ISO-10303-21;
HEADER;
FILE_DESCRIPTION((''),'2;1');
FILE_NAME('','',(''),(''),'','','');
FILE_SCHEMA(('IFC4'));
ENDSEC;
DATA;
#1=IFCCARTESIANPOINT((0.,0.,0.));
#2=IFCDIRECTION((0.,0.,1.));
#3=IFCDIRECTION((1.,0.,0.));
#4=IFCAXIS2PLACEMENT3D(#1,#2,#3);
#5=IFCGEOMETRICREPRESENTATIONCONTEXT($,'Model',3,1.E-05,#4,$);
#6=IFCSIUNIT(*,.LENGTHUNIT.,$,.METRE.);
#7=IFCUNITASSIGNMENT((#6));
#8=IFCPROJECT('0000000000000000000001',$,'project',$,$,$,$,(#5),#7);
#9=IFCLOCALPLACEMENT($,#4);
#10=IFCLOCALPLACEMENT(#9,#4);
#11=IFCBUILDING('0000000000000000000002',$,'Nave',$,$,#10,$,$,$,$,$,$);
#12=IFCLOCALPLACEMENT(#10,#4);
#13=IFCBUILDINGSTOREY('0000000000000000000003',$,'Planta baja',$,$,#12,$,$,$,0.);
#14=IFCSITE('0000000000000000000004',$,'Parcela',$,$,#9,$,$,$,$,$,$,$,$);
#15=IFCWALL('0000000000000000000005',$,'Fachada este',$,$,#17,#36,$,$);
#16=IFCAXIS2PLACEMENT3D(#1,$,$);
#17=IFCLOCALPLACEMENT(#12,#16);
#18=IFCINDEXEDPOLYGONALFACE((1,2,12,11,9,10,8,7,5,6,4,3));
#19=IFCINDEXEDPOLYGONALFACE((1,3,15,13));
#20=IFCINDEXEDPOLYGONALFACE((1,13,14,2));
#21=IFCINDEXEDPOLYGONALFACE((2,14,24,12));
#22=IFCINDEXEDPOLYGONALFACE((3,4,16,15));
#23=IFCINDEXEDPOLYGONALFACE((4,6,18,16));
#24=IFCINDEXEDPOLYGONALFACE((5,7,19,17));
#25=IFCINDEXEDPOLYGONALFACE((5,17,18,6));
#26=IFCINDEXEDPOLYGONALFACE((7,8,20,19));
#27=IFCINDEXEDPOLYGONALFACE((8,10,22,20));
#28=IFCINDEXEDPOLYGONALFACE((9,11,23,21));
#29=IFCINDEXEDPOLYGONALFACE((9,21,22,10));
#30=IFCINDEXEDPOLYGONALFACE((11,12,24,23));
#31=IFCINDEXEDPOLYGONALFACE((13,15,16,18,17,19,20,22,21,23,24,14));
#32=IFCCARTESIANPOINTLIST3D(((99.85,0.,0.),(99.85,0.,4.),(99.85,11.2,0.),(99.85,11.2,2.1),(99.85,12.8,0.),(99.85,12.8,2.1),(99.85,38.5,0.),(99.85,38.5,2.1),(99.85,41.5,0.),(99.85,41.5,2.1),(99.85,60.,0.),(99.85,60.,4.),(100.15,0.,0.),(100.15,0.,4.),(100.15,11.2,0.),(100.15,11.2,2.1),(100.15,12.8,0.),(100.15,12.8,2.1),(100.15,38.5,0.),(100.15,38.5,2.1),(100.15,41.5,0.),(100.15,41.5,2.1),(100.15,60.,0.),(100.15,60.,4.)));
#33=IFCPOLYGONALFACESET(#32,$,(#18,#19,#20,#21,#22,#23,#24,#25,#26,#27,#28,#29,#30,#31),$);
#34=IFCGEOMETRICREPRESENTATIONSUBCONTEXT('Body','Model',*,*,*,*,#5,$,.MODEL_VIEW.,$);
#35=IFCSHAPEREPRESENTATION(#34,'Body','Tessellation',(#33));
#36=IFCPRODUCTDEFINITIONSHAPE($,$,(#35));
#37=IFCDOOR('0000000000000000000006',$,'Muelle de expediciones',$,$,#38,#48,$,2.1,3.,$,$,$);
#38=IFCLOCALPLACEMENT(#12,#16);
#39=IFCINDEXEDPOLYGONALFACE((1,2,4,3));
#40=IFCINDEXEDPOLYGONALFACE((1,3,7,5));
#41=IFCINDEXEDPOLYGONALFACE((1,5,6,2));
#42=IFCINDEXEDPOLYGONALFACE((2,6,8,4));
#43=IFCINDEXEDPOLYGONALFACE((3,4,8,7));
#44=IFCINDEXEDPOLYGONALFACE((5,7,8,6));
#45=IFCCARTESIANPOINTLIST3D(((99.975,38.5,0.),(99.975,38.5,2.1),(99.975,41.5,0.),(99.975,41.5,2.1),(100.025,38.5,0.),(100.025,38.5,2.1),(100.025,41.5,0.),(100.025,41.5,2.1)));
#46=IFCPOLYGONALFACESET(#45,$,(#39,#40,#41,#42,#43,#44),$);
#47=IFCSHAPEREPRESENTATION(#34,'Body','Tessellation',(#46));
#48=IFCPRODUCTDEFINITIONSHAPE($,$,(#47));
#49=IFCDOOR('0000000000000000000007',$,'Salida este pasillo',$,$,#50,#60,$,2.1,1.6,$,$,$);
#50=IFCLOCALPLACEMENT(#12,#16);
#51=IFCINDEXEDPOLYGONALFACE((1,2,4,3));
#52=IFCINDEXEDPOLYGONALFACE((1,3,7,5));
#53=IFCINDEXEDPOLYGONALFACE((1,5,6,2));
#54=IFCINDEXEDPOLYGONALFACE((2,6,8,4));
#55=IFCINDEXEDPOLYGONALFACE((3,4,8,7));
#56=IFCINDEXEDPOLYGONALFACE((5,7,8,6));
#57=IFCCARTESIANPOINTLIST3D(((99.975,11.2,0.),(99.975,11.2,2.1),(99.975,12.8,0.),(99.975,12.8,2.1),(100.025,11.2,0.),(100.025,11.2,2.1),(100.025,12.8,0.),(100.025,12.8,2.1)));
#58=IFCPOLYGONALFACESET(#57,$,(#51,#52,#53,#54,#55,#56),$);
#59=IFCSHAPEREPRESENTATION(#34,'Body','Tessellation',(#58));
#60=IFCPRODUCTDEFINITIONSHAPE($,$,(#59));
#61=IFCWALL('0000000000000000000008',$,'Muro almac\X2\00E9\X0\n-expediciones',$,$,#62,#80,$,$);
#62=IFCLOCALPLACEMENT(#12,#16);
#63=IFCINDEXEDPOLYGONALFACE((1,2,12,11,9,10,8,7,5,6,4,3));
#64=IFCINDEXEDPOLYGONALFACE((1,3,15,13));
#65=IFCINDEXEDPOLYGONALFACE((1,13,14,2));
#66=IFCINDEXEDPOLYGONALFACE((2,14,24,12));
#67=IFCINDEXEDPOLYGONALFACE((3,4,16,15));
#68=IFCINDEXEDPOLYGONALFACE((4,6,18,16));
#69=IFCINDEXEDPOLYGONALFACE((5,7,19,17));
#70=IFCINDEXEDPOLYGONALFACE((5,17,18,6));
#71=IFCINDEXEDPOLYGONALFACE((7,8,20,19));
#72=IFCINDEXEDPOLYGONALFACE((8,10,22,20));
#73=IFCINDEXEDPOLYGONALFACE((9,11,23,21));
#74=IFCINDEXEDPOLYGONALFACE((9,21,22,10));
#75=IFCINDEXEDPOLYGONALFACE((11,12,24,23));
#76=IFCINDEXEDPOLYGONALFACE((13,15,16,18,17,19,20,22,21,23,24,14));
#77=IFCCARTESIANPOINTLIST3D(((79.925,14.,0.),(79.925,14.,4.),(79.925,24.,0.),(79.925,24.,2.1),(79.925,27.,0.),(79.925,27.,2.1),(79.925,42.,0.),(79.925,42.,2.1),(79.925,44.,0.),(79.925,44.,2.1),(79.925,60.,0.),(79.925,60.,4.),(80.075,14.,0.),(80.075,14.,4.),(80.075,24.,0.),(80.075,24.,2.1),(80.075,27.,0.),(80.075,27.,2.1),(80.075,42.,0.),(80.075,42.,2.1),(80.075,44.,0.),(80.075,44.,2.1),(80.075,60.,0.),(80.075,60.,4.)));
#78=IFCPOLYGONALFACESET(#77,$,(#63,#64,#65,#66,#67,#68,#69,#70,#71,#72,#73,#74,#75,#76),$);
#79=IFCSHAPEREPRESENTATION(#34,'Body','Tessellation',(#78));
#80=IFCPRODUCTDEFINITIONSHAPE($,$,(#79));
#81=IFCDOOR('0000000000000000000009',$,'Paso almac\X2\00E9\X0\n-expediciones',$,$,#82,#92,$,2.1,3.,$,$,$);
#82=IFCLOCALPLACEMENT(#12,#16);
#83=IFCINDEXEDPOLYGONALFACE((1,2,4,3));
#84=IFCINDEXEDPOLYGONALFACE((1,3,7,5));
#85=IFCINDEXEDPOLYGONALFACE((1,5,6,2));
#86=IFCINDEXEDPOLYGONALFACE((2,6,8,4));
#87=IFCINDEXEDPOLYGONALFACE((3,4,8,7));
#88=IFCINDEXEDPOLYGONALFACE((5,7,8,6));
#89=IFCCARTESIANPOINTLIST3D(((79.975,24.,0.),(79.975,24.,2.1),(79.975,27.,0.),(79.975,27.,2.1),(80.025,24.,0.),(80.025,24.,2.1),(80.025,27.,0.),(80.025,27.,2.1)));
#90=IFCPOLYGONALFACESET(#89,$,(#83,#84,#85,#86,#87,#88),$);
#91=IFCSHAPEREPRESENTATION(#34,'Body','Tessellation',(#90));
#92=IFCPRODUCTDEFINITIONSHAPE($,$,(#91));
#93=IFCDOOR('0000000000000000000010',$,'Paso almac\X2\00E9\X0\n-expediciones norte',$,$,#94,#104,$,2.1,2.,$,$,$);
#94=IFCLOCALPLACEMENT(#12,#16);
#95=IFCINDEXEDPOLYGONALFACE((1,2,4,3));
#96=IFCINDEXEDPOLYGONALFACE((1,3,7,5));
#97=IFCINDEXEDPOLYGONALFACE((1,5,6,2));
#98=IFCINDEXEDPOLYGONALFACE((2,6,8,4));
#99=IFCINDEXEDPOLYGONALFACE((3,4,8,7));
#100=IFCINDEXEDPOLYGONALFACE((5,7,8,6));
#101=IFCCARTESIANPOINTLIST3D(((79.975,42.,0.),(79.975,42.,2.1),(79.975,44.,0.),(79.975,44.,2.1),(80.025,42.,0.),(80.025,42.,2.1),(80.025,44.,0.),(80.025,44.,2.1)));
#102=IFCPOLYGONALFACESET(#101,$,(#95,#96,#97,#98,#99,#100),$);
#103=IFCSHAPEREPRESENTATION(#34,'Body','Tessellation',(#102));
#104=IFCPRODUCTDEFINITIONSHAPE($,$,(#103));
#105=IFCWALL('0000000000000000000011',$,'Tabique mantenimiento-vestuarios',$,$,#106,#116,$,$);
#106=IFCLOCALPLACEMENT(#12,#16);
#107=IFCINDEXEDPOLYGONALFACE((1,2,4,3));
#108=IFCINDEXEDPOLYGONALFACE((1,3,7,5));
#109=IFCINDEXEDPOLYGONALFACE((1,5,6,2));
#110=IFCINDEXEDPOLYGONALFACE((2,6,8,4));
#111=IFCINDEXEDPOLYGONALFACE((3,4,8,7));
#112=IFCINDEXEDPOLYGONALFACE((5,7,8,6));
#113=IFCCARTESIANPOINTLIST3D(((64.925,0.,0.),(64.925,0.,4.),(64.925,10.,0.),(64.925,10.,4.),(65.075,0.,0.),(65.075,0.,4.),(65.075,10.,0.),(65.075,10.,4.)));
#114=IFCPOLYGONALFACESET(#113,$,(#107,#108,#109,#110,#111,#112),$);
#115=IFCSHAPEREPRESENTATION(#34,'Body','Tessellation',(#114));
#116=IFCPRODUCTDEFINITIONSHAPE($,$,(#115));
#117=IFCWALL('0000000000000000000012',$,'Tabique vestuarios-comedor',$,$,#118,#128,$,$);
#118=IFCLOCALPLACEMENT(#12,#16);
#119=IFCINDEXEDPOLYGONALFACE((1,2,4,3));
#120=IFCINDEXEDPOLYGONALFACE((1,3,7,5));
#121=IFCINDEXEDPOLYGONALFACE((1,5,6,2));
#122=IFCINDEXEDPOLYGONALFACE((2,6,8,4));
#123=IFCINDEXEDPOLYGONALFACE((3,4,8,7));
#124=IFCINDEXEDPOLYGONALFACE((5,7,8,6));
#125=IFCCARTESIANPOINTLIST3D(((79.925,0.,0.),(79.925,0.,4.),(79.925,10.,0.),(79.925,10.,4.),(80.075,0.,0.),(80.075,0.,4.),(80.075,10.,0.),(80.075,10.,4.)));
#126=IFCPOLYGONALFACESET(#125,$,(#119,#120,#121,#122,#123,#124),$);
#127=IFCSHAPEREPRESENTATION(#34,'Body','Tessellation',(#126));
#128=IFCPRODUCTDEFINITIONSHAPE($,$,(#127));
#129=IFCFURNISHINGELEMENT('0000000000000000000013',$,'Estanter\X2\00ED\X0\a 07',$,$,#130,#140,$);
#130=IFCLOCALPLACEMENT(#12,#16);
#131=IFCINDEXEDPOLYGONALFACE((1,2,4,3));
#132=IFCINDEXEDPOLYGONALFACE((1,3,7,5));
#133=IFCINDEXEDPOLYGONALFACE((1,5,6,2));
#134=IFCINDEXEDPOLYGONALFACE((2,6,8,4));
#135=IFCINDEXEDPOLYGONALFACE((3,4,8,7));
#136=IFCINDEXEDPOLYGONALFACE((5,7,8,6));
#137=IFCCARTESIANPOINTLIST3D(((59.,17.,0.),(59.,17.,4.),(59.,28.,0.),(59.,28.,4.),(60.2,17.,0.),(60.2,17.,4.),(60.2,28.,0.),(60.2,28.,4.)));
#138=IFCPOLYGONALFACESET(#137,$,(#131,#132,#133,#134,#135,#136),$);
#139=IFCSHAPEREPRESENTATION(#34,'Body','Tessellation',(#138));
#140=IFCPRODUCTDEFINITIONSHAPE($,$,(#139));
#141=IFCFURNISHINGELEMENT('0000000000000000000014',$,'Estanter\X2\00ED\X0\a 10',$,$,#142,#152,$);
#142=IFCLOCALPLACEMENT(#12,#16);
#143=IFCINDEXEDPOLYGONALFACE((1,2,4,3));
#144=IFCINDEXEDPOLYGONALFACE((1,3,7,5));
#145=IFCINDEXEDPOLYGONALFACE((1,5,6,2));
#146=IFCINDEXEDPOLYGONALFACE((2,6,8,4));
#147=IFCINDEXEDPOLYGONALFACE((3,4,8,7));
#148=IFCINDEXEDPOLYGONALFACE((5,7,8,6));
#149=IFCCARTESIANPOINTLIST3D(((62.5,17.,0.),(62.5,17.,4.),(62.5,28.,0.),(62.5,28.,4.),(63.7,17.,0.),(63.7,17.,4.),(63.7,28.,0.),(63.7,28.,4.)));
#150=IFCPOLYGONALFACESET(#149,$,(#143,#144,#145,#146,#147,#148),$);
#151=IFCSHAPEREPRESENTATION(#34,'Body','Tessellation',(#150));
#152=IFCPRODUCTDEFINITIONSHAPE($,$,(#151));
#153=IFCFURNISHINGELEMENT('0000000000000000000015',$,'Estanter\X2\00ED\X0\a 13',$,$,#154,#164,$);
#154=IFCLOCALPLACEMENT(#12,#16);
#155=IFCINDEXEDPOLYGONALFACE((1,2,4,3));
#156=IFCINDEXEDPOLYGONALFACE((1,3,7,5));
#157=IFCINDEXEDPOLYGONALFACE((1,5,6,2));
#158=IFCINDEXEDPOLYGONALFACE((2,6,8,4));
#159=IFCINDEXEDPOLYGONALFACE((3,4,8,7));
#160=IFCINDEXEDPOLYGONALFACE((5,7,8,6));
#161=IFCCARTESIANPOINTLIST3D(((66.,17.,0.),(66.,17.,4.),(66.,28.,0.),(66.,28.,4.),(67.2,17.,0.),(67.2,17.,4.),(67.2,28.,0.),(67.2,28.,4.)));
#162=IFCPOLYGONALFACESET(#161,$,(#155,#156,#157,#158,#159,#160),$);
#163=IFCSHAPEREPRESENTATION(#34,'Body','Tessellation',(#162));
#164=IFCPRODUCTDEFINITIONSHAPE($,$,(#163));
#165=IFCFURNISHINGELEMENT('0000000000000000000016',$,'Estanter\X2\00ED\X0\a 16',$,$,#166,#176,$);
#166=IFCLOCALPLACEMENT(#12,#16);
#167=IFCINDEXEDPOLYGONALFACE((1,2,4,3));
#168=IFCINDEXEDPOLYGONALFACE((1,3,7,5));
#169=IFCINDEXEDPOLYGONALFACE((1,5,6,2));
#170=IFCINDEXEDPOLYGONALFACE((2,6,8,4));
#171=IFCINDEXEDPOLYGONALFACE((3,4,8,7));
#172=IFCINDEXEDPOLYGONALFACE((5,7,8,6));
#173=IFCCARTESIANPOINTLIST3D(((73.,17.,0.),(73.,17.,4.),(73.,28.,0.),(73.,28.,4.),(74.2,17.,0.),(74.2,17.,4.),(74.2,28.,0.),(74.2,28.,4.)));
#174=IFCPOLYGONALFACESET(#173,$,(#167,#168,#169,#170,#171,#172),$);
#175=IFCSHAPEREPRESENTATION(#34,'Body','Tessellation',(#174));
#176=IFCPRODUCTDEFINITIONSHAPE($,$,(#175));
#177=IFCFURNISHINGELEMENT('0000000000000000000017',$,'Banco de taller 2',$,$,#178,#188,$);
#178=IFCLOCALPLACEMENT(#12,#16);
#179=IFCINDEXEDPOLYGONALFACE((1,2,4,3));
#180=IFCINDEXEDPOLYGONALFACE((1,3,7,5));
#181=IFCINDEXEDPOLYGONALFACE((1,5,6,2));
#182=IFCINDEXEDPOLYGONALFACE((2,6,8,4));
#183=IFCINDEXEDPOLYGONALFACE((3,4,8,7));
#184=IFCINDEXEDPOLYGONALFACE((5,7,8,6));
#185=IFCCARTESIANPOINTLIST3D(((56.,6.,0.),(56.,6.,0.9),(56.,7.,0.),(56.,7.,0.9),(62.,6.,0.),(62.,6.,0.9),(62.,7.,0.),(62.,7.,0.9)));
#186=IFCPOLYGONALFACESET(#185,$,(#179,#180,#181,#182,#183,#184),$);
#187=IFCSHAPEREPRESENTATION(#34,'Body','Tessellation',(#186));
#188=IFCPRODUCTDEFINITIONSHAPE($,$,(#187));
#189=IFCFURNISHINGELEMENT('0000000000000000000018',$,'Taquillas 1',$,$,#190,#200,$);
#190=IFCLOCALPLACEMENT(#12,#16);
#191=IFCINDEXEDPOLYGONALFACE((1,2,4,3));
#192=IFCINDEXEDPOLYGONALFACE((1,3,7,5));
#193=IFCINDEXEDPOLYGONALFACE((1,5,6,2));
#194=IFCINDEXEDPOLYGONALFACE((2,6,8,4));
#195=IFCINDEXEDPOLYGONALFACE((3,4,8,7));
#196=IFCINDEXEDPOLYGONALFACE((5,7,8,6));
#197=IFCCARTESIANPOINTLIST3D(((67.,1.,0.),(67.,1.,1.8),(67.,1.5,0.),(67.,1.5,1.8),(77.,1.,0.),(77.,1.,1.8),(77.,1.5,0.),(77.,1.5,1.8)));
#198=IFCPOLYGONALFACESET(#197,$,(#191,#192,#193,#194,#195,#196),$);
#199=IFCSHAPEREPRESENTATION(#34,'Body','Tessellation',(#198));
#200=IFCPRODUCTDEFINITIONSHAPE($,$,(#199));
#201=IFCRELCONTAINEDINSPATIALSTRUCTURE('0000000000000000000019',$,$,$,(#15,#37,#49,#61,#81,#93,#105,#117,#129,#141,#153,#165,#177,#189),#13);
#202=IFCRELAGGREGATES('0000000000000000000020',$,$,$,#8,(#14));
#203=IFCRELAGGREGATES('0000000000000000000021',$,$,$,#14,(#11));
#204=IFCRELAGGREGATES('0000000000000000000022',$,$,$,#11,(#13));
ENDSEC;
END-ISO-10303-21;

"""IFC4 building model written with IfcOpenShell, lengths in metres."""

from ifc_helpers import new_model, si_unit, frame, origin_with_axes, place, context, subcontext, project, spatial, indexed_curve, outline, extrude, element, fill, save


model = new_model("IFC4")

# Units and contexts
model_context = context("Model", 3, precision=1e-05, world=origin_with_axes())
body_context = subcontext(model_context, "Body", "Model", "MODEL_VIEW")
ifc_project = project(units=[si_unit("LENGTHUNIT", "METRE")], contexts=[model_context])

# Site, building, storey
site_placement = place(None, origin_with_axes())
site = spatial("IfcSite", under=ifc_project, at=site_placement, Name="Parcela")
building_placement = place(site_placement, origin_with_axes())
building = spatial("IfcBuilding", under=site, at=building_placement, Name="Nave")
storey_placement = place(building_placement, origin_with_axes())
storey = spatial("IfcBuildingStorey", under=building, at=storey_placement, Name="Planta baja", Elevation=0.0)

# Walls, openings, doors
wall_1_placement = place(storey_placement, frame((100.15, 0.0, 0.0), z_axis=(0.0, 0.0, 1.0), x_axis=(0.0, 1.0, 0.0)))
wall_1 = element("IfcWall", 1, at=wall_1_placement, inside=storey, Name="Fachada este", context=body_context, shape_type="SweptSolid", body=[
    extrude(outline(indexed_curve([(0.0, 0.0), (0.0, 0.3), (60.0, 0.3), (60.0, 0.0), (0.0, 0.0)], self_intersect=False)), origin_with_axes(), (0.0, 0.0, 1.0), 4.0),
])
opening_1_placement = place(wall_1_placement, frame((38.5, -0.05, 0.0), z_axis=(0.0, 0.0, 1.0), x_axis=(1.0, 0.0, 0.0)))
opening_1 = element("IfcOpeningElement", 2, at=opening_1_placement, cuts=wall_1, context=body_context, shape_type="SweptSolid", body=[
    extrude(outline(indexed_curve([(0.0, 0.0), (0.0, 0.4), (3.0, 0.4), (3.0, 0.0), (0.0, 0.0)], self_intersect=False)), origin_with_axes(), (0.0, 0.0, 1.0), 2.1),
])
opening_2_placement = place(wall_1_placement, frame((11.2, -0.05, 0.0), z_axis=(0.0, 0.0, 1.0), x_axis=(1.0, 0.0, 0.0)))
opening_2 = element("IfcOpeningElement", 3, at=opening_2_placement, cuts=wall_1, context=body_context, shape_type="SweptSolid", body=[
    extrude(outline(indexed_curve([(0.0, 0.0), (0.0, 0.4), (1.6, 0.4), (1.6, 0.0), (0.0, 0.0)], self_intersect=False)), origin_with_axes(), (0.0, 0.0, 1.0), 2.1),
])
door_1_placement = place(opening_1_placement, frame((0.0, 0.175, 0.0), z_axis=(0.0, 0.0, 1.0), x_axis=(1.0, 0.0, 0.0)))
door_1 = element("IfcDoor", 4, at=door_1_placement, inside=storey, Name="Muelle de expediciones", OverallHeight=2.1, OverallWidth=3.0, context=body_context, shape_type="SweptSolid", body=[
    extrude(outline(indexed_curve([(0.0, 0.0), (0.0, 0.05), (3.0, 0.05), (3.0, 0.0), (0.0, 0.0)], self_intersect=False)), origin_with_axes(), (0.0, 0.0, 1.0), 2.1),
])
fill(opening_1, door_1)
door_2_placement = place(opening_2_placement, frame((0.0, 0.175, 0.0), z_axis=(0.0, 0.0, 1.0), x_axis=(1.0, 0.0, 0.0)))
door_2 = element("IfcDoor", 5, at=door_2_placement, inside=storey, Name="Salida este pasillo", OverallHeight=2.1, OverallWidth=1.6, context=body_context, shape_type="SweptSolid", body=[
    extrude(outline(indexed_curve([(0.0, 0.0), (0.0, 0.05), (1.6, 0.05), (1.6, 0.0), (0.0, 0.0)], self_intersect=False)), origin_with_axes(), (0.0, 0.0, 1.0), 2.1),
])
fill(opening_2, door_2)
wall_2_placement = place(storey_placement, frame((80.075, 14.0, 0.0), z_axis=(0.0, 0.0, 1.0), x_axis=(0.0, 1.0, 0.0)))
wall_2 = element("IfcWall", 6, at=wall_2_placement, inside=storey, Name="Muro almacén-expediciones", context=body_context, shape_type="SweptSolid", body=[
    extrude(outline(indexed_curve([(0.0, 0.0), (0.0, 0.15), (46.0, 0.15), (46.0, 0.0), (0.0, 0.0)], self_intersect=False)), origin_with_axes(), (0.0, 0.0, 1.0), 4.0),
])
opening_3_placement = place(wall_2_placement, frame((10.0, -0.05, 0.0), z_axis=(0.0, 0.0, 1.0), x_axis=(1.0, 0.0, 0.0)))
opening_3 = element("IfcOpeningElement", 7, at=opening_3_placement, cuts=wall_2, context=body_context, shape_type="SweptSolid", body=[
    extrude(outline(indexed_curve([(0.0, 0.0), (0.0, 0.25), (3.0, 0.25), (3.0, 0.0), (0.0, 0.0)], self_intersect=False)), origin_with_axes(), (0.0, 0.0, 1.0), 2.1),
])
opening_4_placement = place(wall_2_placement, frame((28.0, -0.05, 0.0), z_axis=(0.0, 0.0, 1.0), x_axis=(1.0, 0.0, 0.0)))
opening_4 = element("IfcOpeningElement", 8, at=opening_4_placement, cuts=wall_2, context=body_context, shape_type="SweptSolid", body=[
    extrude(outline(indexed_curve([(0.0, 0.0), (0.0, 0.25), (2.0, 0.25), (2.0, 0.0), (0.0, 0.0)], self_intersect=False)), origin_with_axes(), (0.0, 0.0, 1.0), 2.1),
])
door_3_placement = place(opening_3_placement, frame((0.0, 0.1, 0.0), z_axis=(0.0, 0.0, 1.0), x_axis=(1.0, 0.0, 0.0)))
door_3 = element("IfcDoor", 9, at=door_3_placement, inside=storey, Name="Paso almacén-expediciones", OverallHeight=2.1, OverallWidth=3.0, context=body_context, shape_type="SweptSolid", body=[
    extrude(outline(indexed_curve([(0.0, 0.0), (0.0, 0.05), (3.0, 0.05), (3.0, 0.0), (0.0, 0.0)], self_intersect=False)), origin_with_axes(), (0.0, 0.0, 1.0), 2.1),
])
fill(opening_3, door_3)
door_4_placement = place(opening_4_placement, frame((0.0, 0.1, 0.0), z_axis=(0.0, 0.0, 1.0), x_axis=(1.0, 0.0, 0.0)))
door_4 = element("IfcDoor", 10, at=door_4_placement, inside=storey, Name="Paso almacén-expediciones norte", OverallHeight=2.1, OverallWidth=2.0, context=body_context, shape_type="SweptSolid", body=[
    extrude(outline(indexed_curve([(0.0, 0.0), (0.0, 0.05), (2.0, 0.05), (2.0, 0.0), (0.0, 0.0)], self_intersect=False)), origin_with_axes(), (0.0, 0.0, 1.0), 2.1),
])
fill(opening_4, door_4)

# Walls
for number, where, z_axis, x_axis, name in (
    (11, (65.075, 0.0, 0.0), (0.0, 0.0, 1.0), (0.0, 1.0, 0.0), "Tabique mantenimiento-vestuarios"),
    (12, (80.075, 0.0, 0.0), (0.0, 0.0, 1.0), (0.0, 1.0, 0.0), "Tabique vestuarios-comedor"),
):
    element("IfcWall", number, at=place(storey_placement, frame(where, z_axis=z_axis, x_axis=x_axis)), inside=storey, Name=name, context=body_context, shape_type="SweptSolid", body=[
        extrude(outline(indexed_curve([(0.0, 0.0), (0.0, 0.15), (10.0, 0.15), (10.0, 0.0), (0.0, 0.0)], self_intersect=False)), origin_with_axes(), (0.0, 0.0, 1.0), 4.0),
    ])

# Furnishing elements
for number, where, z_axis, x_axis, name in (
    (13, (59.0, 17.0, 0.0), (0.0, 0.0, 1.0), (1.0, 0.0, 0.0), "Estantería 07"),
    (14, (62.5, 17.0, 0.0), (0.0, 0.0, 1.0), (1.0, 0.0, 0.0), "Estantería 10"),
    (15, (66.0, 17.0, 0.0), (0.0, 0.0, 1.0), (1.0, 0.0, 0.0), "Estantería 13"),
    (16, (73.0, 17.0, 0.0), (0.0, 0.0, 1.0), (1.0, 0.0, 0.0), "Estantería 16"),
):
    element("IfcFurnishingElement", number, at=place(storey_placement, frame(where, z_axis=z_axis, x_axis=x_axis)), inside=storey, Name=name, context=body_context, shape_type="SweptSolid", body=[
        extrude(outline(indexed_curve([(0.0, 0.0), (0.0, 11.0), (1.2, 11.0), (1.2, 0.0), (0.0, 0.0)], self_intersect=False)), origin_with_axes(), (0.0, 0.0, 1.0), 4.0),
    ])
furnishing_1_placement = place(storey_placement, frame((56.0, 6.0, 0.0), z_axis=(0.0, 0.0, 1.0), x_axis=(1.0, 0.0, 0.0)))
element("IfcFurnishingElement", 17, at=furnishing_1_placement, inside=storey, Name="Banco de taller 2", context=body_context, shape_type="SweptSolid", body=[
    extrude(outline(indexed_curve([(0.0, 0.0), (0.0, 1.0), (6.0, 1.0), (6.0, 0.0), (0.0, 0.0)], self_intersect=False)), origin_with_axes(), (0.0, 0.0, 1.0), 0.9),
])
furnishing_2_placement = place(storey_placement, frame((67.0, 1.0, 0.0), z_axis=(0.0, 0.0, 1.0), x_axis=(1.0, 0.0, 0.0)))
element("IfcFurnishingElement", 18, at=furnishing_2_placement, inside=storey, Name="Taquillas 1", context=body_context, shape_type="SweptSolid", body=[
    extrude(outline(indexed_curve([(0.0, 0.0), (0.0, 0.5), (10.0, 0.5), (10.0, 0.0), (0.0, 0.0)], self_intersect=False)), origin_with_axes(), (0.0, 0.0, 1.0), 1.8),
])

save(model, "model.ifc")
